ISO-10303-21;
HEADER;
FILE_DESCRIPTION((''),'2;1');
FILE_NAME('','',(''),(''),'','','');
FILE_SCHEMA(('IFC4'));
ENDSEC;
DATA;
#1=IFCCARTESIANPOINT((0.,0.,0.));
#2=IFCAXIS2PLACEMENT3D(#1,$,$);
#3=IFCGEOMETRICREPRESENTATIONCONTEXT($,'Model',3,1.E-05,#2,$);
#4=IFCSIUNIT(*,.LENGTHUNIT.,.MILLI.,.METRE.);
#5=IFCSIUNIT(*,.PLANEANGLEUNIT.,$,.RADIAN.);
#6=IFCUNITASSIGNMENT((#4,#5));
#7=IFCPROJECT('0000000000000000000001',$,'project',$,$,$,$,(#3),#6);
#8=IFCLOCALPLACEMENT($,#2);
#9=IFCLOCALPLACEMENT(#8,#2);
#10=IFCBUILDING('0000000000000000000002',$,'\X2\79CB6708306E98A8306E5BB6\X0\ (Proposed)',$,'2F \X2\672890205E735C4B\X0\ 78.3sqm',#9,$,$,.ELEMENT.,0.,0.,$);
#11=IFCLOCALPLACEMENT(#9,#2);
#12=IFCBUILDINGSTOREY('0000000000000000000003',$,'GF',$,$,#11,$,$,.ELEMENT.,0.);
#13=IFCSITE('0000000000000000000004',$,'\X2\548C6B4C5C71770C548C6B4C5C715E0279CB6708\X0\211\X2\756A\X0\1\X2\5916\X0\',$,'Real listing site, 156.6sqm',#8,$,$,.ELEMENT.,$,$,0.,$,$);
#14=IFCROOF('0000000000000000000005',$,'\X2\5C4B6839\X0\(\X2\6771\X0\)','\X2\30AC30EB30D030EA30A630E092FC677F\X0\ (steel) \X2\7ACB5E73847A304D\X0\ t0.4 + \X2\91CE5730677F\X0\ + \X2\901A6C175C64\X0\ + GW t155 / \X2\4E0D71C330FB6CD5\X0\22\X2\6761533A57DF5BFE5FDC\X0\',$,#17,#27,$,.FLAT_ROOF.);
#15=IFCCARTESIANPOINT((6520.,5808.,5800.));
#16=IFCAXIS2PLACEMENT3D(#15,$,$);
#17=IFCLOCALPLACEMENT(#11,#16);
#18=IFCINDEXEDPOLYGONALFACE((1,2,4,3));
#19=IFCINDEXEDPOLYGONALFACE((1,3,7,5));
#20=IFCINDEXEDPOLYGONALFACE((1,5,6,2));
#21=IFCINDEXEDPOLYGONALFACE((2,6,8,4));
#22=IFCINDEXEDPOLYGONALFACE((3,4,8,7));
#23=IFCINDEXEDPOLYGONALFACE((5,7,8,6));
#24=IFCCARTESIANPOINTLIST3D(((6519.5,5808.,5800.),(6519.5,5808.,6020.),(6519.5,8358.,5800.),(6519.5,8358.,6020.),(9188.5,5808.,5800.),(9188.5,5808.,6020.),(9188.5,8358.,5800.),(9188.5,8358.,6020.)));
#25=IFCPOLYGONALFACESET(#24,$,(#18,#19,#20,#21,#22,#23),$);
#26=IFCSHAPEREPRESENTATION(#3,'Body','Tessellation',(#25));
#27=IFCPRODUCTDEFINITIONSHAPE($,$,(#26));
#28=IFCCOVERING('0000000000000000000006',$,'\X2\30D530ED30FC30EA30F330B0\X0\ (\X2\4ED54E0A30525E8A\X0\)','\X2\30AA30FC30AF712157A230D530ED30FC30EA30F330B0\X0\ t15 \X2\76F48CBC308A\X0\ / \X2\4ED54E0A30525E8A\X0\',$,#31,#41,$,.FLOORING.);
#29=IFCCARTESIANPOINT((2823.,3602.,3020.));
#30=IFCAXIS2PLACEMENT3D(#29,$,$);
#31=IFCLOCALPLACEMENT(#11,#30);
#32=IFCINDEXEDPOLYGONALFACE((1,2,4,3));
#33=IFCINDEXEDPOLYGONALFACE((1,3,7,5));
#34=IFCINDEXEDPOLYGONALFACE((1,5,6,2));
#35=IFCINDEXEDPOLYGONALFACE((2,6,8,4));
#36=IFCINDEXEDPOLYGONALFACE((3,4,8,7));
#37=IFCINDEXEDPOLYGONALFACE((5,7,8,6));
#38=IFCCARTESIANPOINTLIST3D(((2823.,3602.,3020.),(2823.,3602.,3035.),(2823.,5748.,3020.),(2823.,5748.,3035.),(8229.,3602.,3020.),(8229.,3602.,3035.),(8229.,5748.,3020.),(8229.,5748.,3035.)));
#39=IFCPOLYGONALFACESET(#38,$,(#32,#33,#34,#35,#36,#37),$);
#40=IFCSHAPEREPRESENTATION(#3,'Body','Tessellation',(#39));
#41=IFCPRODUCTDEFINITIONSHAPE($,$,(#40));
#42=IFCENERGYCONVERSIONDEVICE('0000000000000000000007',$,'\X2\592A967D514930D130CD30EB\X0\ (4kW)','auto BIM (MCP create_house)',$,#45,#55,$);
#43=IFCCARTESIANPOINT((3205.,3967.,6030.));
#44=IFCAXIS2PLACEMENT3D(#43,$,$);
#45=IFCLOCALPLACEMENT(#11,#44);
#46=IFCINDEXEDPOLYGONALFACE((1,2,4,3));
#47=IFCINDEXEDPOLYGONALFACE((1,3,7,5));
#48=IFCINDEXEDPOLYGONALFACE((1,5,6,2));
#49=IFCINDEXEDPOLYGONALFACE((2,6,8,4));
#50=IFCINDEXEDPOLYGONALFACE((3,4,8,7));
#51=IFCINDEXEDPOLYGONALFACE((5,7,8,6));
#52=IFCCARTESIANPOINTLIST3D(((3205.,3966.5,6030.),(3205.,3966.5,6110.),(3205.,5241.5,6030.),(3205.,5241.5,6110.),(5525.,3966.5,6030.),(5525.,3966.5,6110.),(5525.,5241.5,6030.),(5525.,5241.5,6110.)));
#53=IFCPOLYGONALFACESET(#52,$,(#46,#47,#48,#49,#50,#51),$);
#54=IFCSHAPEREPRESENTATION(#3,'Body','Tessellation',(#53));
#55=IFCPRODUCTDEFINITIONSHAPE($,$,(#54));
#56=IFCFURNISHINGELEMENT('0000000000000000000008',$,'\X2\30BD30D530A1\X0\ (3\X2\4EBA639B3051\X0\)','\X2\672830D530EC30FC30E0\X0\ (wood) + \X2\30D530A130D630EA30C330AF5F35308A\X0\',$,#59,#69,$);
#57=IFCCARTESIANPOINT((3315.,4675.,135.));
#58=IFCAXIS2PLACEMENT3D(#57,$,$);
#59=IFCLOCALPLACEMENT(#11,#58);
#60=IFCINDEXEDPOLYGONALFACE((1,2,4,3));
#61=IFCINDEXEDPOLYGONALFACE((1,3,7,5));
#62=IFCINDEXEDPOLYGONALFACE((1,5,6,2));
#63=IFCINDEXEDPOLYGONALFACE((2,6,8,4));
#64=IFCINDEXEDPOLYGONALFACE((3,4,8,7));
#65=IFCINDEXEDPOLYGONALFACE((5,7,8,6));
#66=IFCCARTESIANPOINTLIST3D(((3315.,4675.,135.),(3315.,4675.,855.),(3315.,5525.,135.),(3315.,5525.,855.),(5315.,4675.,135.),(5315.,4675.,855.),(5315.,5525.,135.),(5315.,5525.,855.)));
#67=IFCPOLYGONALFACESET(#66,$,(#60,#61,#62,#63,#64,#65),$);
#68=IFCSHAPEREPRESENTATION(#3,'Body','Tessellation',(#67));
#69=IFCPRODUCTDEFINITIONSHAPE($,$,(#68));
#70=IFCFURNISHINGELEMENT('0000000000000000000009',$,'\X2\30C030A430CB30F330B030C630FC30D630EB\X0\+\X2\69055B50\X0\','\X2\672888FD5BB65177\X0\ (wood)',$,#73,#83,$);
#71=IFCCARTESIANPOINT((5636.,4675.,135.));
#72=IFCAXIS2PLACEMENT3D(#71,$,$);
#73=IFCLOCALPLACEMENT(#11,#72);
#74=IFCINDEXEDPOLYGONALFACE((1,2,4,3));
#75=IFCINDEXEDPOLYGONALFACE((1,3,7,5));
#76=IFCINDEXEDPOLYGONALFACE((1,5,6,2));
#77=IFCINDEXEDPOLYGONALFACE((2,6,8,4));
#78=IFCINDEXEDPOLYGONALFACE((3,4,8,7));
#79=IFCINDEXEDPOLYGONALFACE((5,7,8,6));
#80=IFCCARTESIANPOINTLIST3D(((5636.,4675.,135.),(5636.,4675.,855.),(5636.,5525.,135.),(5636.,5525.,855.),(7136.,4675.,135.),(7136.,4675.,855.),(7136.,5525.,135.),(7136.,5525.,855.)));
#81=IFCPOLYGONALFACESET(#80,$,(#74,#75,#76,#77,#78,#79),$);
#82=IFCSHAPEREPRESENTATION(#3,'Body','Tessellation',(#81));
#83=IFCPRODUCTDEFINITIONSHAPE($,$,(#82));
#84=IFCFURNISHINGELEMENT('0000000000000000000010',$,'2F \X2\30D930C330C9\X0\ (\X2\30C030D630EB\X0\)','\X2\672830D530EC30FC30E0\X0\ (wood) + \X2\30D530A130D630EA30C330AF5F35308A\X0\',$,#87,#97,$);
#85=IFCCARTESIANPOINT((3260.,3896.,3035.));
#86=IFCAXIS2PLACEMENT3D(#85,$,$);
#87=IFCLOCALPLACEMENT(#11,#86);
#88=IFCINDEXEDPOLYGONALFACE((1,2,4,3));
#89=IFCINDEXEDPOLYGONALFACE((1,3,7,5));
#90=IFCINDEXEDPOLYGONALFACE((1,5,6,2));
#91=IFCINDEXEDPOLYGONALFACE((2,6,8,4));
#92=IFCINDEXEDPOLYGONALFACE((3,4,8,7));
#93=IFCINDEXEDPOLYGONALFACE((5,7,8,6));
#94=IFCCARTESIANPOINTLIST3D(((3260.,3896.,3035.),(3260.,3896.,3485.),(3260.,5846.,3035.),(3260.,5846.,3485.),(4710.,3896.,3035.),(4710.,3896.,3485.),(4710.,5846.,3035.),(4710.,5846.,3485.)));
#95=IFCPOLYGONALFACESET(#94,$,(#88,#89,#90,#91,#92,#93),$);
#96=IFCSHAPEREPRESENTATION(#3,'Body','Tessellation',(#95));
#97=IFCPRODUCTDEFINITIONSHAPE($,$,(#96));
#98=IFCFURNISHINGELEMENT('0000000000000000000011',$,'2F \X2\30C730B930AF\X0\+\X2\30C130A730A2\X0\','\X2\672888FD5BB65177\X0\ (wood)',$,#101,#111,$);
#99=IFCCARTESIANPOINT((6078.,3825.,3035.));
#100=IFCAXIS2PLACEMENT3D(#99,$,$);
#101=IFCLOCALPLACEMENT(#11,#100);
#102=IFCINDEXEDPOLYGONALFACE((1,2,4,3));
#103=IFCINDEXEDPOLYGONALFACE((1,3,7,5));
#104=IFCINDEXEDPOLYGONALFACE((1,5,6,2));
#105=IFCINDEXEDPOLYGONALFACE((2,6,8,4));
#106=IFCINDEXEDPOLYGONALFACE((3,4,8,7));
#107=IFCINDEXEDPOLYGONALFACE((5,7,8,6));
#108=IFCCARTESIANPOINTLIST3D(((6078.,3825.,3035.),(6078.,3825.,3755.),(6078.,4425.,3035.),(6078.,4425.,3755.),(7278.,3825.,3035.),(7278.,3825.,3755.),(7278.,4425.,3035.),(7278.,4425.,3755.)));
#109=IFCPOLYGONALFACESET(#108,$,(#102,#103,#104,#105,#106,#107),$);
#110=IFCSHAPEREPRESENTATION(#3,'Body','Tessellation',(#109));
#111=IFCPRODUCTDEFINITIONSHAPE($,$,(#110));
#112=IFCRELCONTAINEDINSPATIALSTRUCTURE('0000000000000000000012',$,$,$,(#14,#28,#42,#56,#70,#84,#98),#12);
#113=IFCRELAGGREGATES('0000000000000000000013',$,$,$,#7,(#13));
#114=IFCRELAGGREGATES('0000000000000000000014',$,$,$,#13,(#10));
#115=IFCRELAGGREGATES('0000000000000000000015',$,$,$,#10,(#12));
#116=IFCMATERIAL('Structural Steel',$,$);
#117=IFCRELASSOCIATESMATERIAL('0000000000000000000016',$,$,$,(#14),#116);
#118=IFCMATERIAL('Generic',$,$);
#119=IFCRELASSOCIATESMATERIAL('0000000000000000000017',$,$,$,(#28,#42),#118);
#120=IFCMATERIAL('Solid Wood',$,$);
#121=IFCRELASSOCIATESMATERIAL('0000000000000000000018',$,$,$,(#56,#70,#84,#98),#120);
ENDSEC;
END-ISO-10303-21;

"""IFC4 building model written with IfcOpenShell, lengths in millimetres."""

from ifc_helpers import new_model, si_unit, frame, frame_2d, origin, place, context, project, spatial, rectangle, extrude, material, element, save


model = new_model("IFC4")

# Units and contexts
model_context = context("Model", 3, precision=1e-05, world=origin())
ifc_project = project(units=[si_unit("LENGTHUNIT", "METRE", prefix="MILLI"), si_unit("PLANEANGLEUNIT", "RADIAN")], contexts=[model_context])

# Site, building, storey
site_placement = place(None, origin())
site = spatial("IfcSite", under=ifc_project, at=site_placement, Name="和歌山県和歌山市秋月211番1外", ObjectType="Real listing site, 156.6sqm", CompositionType="ELEMENT", RefElevation=0.0)
building_placement = place(site_placement, origin())
building = spatial("IfcBuilding", under=site, at=building_placement, Name="秋月の風の家 (Proposed)", ObjectType="2F 木造平屋 78.3sqm", CompositionType="ELEMENT", ElevationOfRefHeight=0.0, ElevationOfTerrain=0.0)
storey_placement = place(building_placement, origin())
storey = spatial("IfcBuildingStorey", under=building, at=storey_placement, Name="GF", CompositionType="ELEMENT", Elevation=0.0)

# Shared definitions
ifc_material_1 = material(Name="Solid Wood")

# Roof
ifc_material_2 = material(Name="Structural Steel")
roof_1_placement = place(storey_placement, frame((6520.0, 5808.0, 5800.0)))
element("IfcRoof", 1, at=roof_1_placement, inside=storey, material=ifc_material_2, Name="屋根(東)", Description="ガルバリウム鋼板 (steel) 立平葺き t0.4 + 野地板 + 通気層 + GW t155 / 不燃・法22条区域対応", PredefinedType="FLAT_ROOF", context=model_context, shape_type="SweptSolid", body=[
    extrude(rectangle(XDim=2669.0, YDim=2550.0, at=frame_2d((1334.0, 1275.0))), frame((6520.0, 5808.0, 5800.0)), (0.0, 0.0, 1.0), 220.0),
])

# Covering
ifc_material_3 = material(Name="Generic")
covering_placement = place(storey_placement, frame((2823.0, 3602.0, 3020.0)))
element("IfcCovering", 2, at=covering_placement, inside=storey, material=ifc_material_3, Name="フローリング (仕上げ床)", Description="オーク無垢フローリング t15 直貼り / 仕上げ床", PredefinedType="FLOORING", context=model_context, shape_type="SweptSolid", body=[
    extrude(rectangle(XDim=5406.0, YDim=2146.0, at=frame_2d((2703.0, 1073.0))), frame((2823.0, 3602.0, 3020.0)), (0.0, 0.0, 1.0), 15.0),
])

# Energy conversion device
energy_conversion_device_placement = place(storey_placement, frame((3205.0, 3967.0, 6030.0)))
element("IfcEnergyConversionDevice", 3, at=energy_conversion_device_placement, inside=storey, material=ifc_material_3, Name="太陽光パネル (4kW)", Description="auto BIM (MCP create_house)", context=model_context, shape_type="SweptSolid", body=[
    extrude(rectangle(XDim=2320.0, YDim=1275.0, at=frame_2d((1160.0, 637.0))), frame((3205.0, 3967.0, 6030.0)), (0.0, 0.0, 1.0), 80.0),
])

# Furnishing elements
furnishing_1_placement = place(storey_placement, frame((3315.0, 4675.0, 135.0)))
element("IfcFurnishingElement", 4, at=furnishing_1_placement, inside=storey, material=ifc_material_1, Name="ソファ (3人掛け)", Description="木フレーム (wood) + ファブリック張り", context=model_context, shape_type="SweptSolid", body=[
    extrude(rectangle(XDim=2000.0, YDim=850.0, at=frame_2d((1000.0, 425.0))), frame((3315.0, 4675.0, 135.0)), (0.0, 0.0, 1.0), 720.0),
])
furnishing_2_placement = place(storey_placement, frame((5636.0, 4675.0, 135.0)))
element("IfcFurnishingElement", 5, at=furnishing_2_placement, inside=storey, material=ifc_material_1, Name="ダイニングテーブル+椅子", Description="木製家具 (wood)", context=model_context, shape_type="SweptSolid", body=[
    extrude(rectangle(XDim=1500.0, YDim=850.0, at=frame_2d((750.0, 425.0))), frame((5636.0, 4675.0, 135.0)), (0.0, 0.0, 1.0), 720.0),
])
furnishing_3_placement = place(storey_placement, frame((3260.0, 3896.0, 3035.0)))
element("IfcFurnishingElement", 6, at=furnishing_3_placement, inside=storey, material=ifc_material_1, Name="2F ベッド (ダブル)", Description="木フレーム (wood) + ファブリック張り", context=model_context, shape_type="SweptSolid", body=[
    extrude(rectangle(XDim=1450.0, YDim=1950.0, at=frame_2d((725.0, 975.0))), frame((3260.0, 3896.0, 3035.0)), (0.0, 0.0, 1.0), 450.0),
])
furnishing_4_placement = place(storey_placement, frame((6078.0, 3825.0, 3035.0)))
element("IfcFurnishingElement", 7, at=furnishing_4_placement, inside=storey, material=ifc_material_1, Name="2F デスク+チェア", Description="木製家具 (wood)", context=model_context, shape_type="SweptSolid", body=[
    extrude(rectangle(XDim=1200.0, YDim=600.0, at=frame_2d((600.0, 300.0))), frame((6078.0, 3825.0, 3035.0)), (0.0, 0.0, 1.0), 720.0),
])

save(model, "model.ifc")
